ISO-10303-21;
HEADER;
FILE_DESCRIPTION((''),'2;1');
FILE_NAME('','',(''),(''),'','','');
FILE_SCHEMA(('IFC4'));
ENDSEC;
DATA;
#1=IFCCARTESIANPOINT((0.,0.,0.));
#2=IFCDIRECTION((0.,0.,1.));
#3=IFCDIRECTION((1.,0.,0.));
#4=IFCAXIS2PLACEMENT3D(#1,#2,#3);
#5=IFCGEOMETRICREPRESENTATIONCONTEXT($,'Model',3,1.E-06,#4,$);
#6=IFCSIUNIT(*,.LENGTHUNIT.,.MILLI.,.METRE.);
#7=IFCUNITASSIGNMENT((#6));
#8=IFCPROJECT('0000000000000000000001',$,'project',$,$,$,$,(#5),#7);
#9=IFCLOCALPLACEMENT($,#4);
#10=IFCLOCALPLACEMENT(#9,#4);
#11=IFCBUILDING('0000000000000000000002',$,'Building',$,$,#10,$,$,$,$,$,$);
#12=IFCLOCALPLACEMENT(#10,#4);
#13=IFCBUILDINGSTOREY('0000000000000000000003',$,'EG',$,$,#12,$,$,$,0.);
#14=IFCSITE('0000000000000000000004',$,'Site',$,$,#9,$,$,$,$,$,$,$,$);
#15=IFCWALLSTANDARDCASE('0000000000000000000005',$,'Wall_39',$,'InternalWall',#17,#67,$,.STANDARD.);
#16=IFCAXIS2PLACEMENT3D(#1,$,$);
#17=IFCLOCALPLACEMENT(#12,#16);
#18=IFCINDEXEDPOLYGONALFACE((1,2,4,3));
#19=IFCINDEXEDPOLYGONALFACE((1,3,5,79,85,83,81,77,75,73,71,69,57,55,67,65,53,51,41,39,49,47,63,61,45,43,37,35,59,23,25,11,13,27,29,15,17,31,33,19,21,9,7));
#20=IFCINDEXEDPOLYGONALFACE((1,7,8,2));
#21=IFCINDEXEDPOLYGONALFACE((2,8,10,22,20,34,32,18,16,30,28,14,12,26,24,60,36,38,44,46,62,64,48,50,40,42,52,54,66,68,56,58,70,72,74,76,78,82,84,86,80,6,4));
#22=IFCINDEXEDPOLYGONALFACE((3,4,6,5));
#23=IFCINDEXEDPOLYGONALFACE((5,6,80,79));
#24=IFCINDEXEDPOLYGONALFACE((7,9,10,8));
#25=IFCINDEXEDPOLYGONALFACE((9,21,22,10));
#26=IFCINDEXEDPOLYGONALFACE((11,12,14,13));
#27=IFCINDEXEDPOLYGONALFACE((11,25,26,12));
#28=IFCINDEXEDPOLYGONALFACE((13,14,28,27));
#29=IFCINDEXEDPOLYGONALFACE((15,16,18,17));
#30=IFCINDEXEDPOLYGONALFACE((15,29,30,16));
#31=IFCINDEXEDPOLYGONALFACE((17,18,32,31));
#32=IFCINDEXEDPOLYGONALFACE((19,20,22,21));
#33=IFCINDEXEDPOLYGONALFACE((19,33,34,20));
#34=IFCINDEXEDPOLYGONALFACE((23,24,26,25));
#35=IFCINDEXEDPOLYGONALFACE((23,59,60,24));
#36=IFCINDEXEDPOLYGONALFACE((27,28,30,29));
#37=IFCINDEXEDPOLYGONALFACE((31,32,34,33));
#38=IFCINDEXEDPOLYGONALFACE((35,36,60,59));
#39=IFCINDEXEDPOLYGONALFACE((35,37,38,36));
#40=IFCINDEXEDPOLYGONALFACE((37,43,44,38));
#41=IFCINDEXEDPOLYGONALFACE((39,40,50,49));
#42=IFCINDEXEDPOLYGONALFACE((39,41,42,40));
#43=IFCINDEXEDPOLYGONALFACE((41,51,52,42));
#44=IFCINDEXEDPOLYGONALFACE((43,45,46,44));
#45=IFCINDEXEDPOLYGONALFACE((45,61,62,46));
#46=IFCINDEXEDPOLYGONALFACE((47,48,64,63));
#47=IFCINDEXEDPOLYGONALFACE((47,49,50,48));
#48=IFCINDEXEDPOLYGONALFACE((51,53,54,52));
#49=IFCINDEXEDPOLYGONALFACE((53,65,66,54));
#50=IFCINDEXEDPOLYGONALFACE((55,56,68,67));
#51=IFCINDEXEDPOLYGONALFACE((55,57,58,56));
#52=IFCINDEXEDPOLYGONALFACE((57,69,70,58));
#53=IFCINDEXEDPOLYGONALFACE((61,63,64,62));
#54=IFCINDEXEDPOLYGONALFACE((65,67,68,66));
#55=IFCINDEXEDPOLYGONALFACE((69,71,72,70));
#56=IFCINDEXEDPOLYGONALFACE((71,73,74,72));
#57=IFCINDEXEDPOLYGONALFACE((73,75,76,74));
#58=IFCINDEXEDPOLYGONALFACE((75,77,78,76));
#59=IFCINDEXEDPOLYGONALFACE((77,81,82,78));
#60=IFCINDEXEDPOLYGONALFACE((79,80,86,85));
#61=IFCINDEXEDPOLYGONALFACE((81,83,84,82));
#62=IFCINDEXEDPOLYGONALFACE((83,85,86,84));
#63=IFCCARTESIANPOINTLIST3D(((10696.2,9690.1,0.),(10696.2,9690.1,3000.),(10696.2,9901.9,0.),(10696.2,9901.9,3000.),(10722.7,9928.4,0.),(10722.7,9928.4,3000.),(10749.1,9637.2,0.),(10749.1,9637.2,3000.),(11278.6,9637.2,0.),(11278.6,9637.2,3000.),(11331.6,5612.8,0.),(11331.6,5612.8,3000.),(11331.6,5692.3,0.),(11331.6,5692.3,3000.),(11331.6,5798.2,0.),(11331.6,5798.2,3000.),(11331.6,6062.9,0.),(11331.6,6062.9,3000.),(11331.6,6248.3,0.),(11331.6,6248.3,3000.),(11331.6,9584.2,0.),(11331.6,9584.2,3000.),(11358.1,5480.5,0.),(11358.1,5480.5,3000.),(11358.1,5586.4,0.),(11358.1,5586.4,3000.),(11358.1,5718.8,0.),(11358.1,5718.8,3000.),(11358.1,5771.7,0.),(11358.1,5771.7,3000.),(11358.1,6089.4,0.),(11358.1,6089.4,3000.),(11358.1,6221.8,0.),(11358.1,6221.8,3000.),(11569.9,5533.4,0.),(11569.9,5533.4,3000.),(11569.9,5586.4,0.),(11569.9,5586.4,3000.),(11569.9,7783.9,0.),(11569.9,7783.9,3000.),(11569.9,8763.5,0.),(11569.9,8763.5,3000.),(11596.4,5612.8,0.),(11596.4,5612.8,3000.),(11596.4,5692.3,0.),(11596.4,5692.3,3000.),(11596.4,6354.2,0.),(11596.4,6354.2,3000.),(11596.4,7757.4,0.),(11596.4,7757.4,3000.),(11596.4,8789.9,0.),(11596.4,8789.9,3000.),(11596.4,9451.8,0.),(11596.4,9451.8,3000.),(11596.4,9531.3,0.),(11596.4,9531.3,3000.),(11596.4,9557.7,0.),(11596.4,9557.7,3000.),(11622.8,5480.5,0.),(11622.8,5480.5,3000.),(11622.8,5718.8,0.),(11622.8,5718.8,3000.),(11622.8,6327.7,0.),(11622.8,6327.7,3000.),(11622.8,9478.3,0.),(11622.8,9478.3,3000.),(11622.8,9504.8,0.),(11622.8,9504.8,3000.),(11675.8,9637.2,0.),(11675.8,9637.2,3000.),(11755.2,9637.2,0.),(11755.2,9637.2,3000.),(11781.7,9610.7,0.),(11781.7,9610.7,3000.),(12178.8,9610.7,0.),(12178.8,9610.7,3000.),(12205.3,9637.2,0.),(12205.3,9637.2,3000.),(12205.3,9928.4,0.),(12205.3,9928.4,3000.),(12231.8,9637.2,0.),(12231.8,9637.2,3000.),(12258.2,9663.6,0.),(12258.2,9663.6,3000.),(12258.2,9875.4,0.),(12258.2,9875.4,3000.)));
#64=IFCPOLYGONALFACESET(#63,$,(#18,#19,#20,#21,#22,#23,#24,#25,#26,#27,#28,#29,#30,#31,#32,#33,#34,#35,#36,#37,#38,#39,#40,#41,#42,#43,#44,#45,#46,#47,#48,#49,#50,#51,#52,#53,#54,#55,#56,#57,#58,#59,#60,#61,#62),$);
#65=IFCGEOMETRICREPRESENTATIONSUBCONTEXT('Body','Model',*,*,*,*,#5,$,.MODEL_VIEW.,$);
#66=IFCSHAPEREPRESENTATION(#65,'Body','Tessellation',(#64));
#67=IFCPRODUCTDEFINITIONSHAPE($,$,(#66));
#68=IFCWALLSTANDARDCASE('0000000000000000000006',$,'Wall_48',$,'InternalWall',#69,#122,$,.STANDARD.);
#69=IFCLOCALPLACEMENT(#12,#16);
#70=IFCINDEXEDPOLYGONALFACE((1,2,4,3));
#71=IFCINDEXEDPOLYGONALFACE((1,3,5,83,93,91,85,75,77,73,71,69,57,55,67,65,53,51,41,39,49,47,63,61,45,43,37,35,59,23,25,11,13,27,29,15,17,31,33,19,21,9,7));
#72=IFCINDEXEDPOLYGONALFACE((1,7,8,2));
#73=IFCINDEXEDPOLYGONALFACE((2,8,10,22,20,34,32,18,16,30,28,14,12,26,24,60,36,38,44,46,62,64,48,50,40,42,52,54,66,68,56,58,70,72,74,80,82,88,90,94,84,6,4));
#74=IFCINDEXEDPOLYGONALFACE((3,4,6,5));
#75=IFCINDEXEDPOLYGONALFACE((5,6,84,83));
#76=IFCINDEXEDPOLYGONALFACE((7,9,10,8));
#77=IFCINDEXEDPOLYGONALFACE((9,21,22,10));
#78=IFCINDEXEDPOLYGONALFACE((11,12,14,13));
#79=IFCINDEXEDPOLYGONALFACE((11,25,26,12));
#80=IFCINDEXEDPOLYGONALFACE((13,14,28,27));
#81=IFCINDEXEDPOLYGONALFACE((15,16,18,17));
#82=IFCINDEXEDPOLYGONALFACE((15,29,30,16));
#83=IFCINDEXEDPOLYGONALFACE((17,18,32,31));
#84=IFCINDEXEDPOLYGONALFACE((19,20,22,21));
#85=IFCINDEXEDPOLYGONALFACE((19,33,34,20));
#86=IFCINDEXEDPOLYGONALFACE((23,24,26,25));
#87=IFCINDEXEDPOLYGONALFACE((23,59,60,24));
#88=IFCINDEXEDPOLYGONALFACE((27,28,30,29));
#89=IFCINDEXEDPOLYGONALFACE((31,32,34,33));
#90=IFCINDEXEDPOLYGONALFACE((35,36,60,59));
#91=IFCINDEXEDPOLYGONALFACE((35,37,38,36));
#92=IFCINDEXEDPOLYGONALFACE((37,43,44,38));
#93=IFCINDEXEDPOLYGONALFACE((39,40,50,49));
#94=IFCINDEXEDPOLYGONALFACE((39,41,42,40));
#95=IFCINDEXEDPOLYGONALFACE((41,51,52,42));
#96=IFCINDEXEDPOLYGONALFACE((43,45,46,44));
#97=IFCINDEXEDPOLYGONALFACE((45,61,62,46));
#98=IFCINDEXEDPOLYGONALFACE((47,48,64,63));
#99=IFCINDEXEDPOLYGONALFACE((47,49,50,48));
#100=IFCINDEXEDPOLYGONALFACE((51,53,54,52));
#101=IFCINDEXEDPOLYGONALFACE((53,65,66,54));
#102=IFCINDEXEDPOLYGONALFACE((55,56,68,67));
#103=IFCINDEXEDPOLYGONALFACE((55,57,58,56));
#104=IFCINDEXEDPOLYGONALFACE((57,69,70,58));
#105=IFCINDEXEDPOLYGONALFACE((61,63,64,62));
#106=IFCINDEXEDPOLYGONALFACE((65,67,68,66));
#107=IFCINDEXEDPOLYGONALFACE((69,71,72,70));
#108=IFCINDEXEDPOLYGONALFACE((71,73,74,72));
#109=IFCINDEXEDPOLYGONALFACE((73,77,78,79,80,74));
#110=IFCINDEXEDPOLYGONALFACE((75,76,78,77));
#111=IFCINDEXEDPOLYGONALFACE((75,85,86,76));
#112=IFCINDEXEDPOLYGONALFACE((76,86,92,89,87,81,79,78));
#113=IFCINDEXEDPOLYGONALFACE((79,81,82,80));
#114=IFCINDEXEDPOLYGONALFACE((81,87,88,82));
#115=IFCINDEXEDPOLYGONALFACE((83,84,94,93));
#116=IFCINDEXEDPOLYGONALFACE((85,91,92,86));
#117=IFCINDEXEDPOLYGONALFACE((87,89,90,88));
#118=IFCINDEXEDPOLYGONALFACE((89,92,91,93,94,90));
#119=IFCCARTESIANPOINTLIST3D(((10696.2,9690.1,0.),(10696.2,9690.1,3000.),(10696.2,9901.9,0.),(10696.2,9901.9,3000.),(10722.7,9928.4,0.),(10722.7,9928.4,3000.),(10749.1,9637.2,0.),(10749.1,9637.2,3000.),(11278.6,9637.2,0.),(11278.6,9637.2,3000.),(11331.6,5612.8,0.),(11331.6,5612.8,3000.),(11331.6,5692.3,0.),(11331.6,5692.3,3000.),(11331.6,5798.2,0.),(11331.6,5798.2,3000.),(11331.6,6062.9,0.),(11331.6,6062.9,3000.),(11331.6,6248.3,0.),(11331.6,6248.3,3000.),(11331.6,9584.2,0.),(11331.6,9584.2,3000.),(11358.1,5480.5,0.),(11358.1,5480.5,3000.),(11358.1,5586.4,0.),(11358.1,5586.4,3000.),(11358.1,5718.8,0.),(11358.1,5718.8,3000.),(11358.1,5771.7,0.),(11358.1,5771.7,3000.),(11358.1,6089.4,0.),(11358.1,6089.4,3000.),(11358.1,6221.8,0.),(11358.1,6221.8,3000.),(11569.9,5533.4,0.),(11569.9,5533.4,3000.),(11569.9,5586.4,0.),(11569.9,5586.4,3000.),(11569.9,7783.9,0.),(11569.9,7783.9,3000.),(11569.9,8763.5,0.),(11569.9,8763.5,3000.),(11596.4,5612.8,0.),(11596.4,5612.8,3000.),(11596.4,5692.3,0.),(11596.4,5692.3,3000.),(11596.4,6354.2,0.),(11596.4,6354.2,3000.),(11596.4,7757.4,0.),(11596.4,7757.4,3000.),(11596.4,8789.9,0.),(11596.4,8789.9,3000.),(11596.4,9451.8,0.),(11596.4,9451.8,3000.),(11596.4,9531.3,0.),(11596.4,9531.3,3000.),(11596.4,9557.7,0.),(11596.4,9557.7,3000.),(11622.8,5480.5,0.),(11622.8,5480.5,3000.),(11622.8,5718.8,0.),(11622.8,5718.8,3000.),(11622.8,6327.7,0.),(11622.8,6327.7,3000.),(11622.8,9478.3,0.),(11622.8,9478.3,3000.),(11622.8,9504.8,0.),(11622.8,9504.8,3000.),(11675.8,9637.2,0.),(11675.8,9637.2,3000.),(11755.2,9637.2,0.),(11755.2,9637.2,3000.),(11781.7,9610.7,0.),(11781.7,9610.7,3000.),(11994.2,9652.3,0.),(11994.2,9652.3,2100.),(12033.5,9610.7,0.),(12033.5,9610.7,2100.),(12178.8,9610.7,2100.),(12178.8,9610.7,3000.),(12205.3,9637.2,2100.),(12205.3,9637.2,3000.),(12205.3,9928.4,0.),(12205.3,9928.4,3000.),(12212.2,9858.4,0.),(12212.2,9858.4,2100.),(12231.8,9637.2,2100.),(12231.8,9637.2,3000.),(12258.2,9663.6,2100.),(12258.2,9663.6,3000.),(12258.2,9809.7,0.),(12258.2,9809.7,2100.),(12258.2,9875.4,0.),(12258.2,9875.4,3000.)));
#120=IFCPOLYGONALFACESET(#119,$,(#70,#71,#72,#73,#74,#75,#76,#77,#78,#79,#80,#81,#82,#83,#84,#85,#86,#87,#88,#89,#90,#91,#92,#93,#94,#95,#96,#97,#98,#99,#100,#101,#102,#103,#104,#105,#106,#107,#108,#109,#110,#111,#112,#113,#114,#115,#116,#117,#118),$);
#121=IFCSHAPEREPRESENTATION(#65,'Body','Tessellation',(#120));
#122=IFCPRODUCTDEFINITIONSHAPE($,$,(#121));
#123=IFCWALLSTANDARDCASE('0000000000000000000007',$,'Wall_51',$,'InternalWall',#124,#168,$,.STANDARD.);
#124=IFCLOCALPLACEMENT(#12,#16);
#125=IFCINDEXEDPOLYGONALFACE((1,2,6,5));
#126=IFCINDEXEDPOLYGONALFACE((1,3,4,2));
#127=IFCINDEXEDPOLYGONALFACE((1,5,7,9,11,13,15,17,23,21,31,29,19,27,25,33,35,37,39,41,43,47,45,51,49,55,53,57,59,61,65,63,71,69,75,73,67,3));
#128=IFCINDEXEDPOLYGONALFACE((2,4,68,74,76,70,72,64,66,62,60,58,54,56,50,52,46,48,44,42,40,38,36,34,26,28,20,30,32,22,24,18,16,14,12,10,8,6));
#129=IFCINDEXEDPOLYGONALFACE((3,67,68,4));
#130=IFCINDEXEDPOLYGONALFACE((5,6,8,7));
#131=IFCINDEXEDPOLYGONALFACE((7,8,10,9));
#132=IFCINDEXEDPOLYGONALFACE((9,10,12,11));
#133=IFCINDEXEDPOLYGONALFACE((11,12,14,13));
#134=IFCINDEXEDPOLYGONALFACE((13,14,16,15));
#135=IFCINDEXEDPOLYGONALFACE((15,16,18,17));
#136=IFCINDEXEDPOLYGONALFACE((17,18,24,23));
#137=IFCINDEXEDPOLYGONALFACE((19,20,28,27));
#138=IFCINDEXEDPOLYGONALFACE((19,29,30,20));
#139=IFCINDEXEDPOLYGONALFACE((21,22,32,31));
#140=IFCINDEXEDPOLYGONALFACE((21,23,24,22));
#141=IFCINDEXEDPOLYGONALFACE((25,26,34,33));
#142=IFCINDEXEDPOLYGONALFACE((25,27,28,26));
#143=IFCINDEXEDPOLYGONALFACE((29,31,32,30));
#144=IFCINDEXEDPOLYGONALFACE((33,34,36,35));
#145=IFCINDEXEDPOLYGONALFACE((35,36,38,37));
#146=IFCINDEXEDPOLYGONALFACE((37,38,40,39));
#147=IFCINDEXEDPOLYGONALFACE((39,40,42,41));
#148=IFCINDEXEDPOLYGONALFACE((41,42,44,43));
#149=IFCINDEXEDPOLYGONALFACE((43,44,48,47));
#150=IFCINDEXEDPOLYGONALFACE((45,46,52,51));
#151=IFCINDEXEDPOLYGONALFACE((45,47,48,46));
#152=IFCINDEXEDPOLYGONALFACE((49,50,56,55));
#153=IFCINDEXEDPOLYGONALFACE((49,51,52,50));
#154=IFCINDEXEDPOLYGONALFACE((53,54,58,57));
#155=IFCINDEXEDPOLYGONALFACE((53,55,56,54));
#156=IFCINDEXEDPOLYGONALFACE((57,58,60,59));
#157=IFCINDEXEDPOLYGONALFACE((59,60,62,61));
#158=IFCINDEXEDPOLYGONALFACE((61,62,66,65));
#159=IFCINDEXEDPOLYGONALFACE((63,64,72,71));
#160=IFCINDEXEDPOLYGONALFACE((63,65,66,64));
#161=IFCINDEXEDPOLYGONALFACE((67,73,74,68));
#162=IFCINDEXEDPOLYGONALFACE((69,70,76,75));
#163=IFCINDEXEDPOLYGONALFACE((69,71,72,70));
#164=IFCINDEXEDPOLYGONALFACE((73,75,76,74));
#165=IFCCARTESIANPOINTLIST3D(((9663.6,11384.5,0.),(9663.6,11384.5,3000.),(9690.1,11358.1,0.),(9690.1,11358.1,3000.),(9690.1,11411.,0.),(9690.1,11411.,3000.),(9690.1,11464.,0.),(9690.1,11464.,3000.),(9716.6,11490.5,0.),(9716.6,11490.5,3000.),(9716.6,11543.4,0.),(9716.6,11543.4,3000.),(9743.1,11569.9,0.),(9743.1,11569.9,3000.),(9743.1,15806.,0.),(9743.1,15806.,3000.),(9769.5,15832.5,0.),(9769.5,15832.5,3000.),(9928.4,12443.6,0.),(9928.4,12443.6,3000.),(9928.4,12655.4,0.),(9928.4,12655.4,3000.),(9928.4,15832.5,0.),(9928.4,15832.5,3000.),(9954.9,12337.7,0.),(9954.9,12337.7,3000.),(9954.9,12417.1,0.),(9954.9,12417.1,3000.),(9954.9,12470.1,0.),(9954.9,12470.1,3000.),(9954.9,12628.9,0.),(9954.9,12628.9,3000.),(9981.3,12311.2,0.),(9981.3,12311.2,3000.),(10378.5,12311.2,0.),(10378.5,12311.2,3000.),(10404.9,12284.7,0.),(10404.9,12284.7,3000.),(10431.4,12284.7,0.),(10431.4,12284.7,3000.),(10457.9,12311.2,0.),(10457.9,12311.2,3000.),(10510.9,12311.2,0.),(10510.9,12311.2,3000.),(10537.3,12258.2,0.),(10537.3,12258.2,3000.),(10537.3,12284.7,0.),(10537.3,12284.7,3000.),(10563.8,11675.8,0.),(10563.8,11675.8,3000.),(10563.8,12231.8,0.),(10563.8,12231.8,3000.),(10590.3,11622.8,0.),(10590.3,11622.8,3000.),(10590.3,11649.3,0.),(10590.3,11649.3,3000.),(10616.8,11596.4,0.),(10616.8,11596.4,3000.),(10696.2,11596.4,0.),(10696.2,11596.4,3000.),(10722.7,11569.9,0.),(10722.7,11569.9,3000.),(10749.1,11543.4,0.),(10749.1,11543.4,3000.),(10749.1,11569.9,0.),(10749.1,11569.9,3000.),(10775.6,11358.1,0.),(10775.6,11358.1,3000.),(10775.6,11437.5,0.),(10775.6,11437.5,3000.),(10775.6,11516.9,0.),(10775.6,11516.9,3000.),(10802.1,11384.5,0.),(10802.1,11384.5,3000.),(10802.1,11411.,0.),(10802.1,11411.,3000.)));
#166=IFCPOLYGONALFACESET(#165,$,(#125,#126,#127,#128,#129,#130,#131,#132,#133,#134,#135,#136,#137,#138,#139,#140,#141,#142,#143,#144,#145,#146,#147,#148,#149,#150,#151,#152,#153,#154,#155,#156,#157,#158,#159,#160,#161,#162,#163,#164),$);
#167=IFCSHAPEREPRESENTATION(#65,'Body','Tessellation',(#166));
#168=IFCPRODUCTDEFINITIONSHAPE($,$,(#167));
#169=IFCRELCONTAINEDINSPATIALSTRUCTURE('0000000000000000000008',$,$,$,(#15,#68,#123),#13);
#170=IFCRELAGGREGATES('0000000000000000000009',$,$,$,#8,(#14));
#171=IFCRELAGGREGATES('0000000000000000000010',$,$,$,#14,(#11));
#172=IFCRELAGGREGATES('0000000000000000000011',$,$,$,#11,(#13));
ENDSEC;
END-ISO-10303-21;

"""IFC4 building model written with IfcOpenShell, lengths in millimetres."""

from ifc_helpers import new_model, si_unit, frame, origin_with_axes, place, context, subcontext, project, spatial, polyline, rectangle, outline, extrude, element, save


model = new_model("IFC4")

# Units and contexts
model_context = context("Model", 3, precision=1e-06, world=origin_with_axes())
body_context = subcontext(model_context, "Body", "Model", "MODEL_VIEW")
ifc_project = project(units=[si_unit("LENGTHUNIT", "METRE", prefix="MILLI")], contexts=[model_context])

# Site, building, storey
site_placement = place(None, origin_with_axes())
site = spatial("IfcSite", under=ifc_project, at=site_placement, Name="Site")
building_placement = place(site_placement, origin_with_axes())
building = spatial("IfcBuilding", under=site, at=building_placement, Name="Building")
storey_placement = place(building_placement, origin_with_axes())
storey = spatial("IfcBuildingStorey", under=building, at=storey_placement, Name="EG", Elevation=0.0)

# Wall
wall_1_placement = place(storey_placement, origin_with_axes())
element("IfcWallStandardCase", 1, at=wall_1_placement, inside=storey, Name="Wall_39", ObjectType="InternalWall", PredefinedType="STANDARD", context=body_context, shape_type="SweptSolid", body=[
    extrude(outline(polyline([(11358.1, 5480.5, 0.0), (11358.1, 5586.4, 0.0), (11331.6, 5612.8, 0.0), (11331.6, 5692.3, 0.0), (11358.1, 5718.8, 0.0), (11358.1, 5771.7, 0.0), (11331.6, 5798.2, 0.0), (11331.6, 6062.9, 0.0), (11358.1, 6089.4, 0.0), (11358.1, 6221.8, 0.0), (11331.6, 6248.3, 0.0), (11331.6, 9584.2, 0.0), (11278.6, 9637.2, 0.0), (10749.1, 9637.2, 0.0), (10696.2, 9690.1, 0.0), (10696.2, 9901.9, 0.0), (10722.7, 9928.4, 0.0), (12205.3, 9928.4, 0.0), (12258.2, 9875.4, 0.0), (12258.2, 9663.6, 0.0), (12231.8, 9637.2, 0.0), (12205.3, 9637.2, 0.0), (12178.8, 9610.7, 0.0), (11781.7, 9610.7, 0.0), (11755.2, 9637.2, 0.0), (11675.8, 9637.2, 0.0), (11596.4, 9557.7, 0.0), (11596.4, 9531.3, 0.0), (11622.8, 9504.8, 0.0), (11622.8, 9478.3, 0.0), (11596.4, 9451.8, 0.0), (11596.4, 8789.9, 0.0), (11569.9, 8763.5, 0.0), (11569.9, 7783.9, 0.0), (11596.4, 7757.4, 0.0), (11596.4, 6354.2, 0.0), (11622.8, 6327.7, 0.0), (11622.8, 5718.8, 0.0), (11596.4, 5692.3, 0.0), (11596.4, 5612.8, 0.0), (11569.9, 5586.4, 0.0), (11569.9, 5533.4, 0.0), (11622.8, 5480.5, 0.0), (11358.1, 5480.5, 0.0)])), origin_with_axes(), (0.0, 0.0, 1.0), 3000.0),
])

# Wall, opening
wall_2_placement = place(storey_placement, origin_with_axes())
wall_2 = element("IfcWallStandardCase", 2, at=wall_2_placement, inside=storey, Name="Wall_48", ObjectType="InternalWall", PredefinedType="STANDARD", context=body_context, shape_type="SweptSolid", body=[
    extrude(outline(polyline([(11358.1, 5480.5, 0.0), (11358.1, 5586.4, 0.0), (11331.6, 5612.8, 0.0), (11331.6, 5692.3, 0.0), (11358.1, 5718.8, 0.0), (11358.1, 5771.7, 0.0), (11331.6, 5798.2, 0.0), (11331.6, 6062.9, 0.0), (11358.1, 6089.4, 0.0), (11358.1, 6221.8, 0.0), (11331.6, 6248.3, 0.0), (11331.6, 9584.2, 0.0), (11278.6, 9637.2, 0.0), (10749.1, 9637.2, 0.0), (10696.2, 9690.1, 0.0), (10696.2, 9901.9, 0.0), (10722.7, 9928.4, 0.0), (12205.3, 9928.4, 0.0), (12258.2, 9875.4, 0.0), (12258.2, 9663.6, 0.0), (12231.8, 9637.2, 0.0), (12205.3, 9637.2, 0.0), (12178.8, 9610.7, 0.0), (11781.7, 9610.7, 0.0), (11755.2, 9637.2, 0.0), (11675.8, 9637.2, 0.0), (11596.4, 9557.7, 0.0), (11596.4, 9531.3, 0.0), (11622.8, 9504.8, 0.0), (11622.8, 9478.3, 0.0), (11596.4, 9451.8, 0.0), (11596.4, 8789.9, 0.0), (11569.9, 8763.5, 0.0), (11569.9, 7783.9, 0.0), (11596.4, 7757.4, 0.0), (11596.4, 6354.2, 0.0), (11622.8, 6327.7, 0.0), (11622.8, 5718.8, 0.0), (11596.4, 5692.3, 0.0), (11596.4, 5612.8, 0.0), (11569.9, 5586.4, 0.0), (11569.9, 5533.4, 0.0), (11622.8, 5480.5, 0.0), (11358.1, 5480.5, 0.0)])), origin_with_axes(), (0.0, 0.0, 1.0), 3000.0),
])
opening_1_placement = place(wall_2_placement, origin_with_axes())
element("IfcOpeningElement", 3, at=opening_1_placement, inside=storey, cuts=wall_2, context=body_context, shape_type="SweptSolid", body=[
    extrude(rectangle(XDim=1319.5, YDim=300.0), frame((12556.4, 9275.9, 0.0), z_axis=(0.0, 0.0, 1.0), x_axis=(0.686906, -0.726747, 0.0)), (0.0, 0.0, 1.0), 2100.0),
])

# Wall
for number, where, z_axis, x_axis, name in (
    (4, (0.0, 0.0, 0.0), (0.0, 0.0, 1.0), (1.0, 0.0, 0.0), "Wall_51"),
):
    element("IfcWallStandardCase", number, at=place(storey_placement, frame(where, z_axis=z_axis, x_axis=x_axis)), inside=storey, Name=name, ObjectType="InternalWall", PredefinedType="STANDARD", context=body_context, shape_type="SweptSolid", body=[
        extrude(outline(polyline([(9690.1, 11358.1, 0.0), (9663.6, 11384.5, 0.0), (9690.1, 11411.0, 0.0), (9690.1, 11464.0, 0.0), (9716.6, 11490.5, 0.0), (9716.6, 11543.4, 0.0), (9743.1, 11569.9, 0.0), (9743.1, 15806.0, 0.0), (9769.5, 15832.5, 0.0), (9928.4, 15832.5, 0.0), (9928.4, 12655.4, 0.0), (9954.9, 12628.9, 0.0), (9954.9, 12470.1, 0.0), (9928.4, 12443.6, 0.0), (9954.9, 12417.1, 0.0), (9954.9, 12337.7, 0.0), (9981.3, 12311.2, 0.0), (10378.5, 12311.2, 0.0), (10404.9, 12284.7, 0.0), (10431.4, 12284.7, 0.0), (10457.9, 12311.2, 0.0), (10510.9, 12311.2, 0.0), (10537.3, 12284.7, 0.0), (10537.3, 12258.2, 0.0), (10563.8, 12231.8, 0.0), (10563.8, 11675.8, 0.0), (10590.3, 11649.3, 0.0), (10590.3, 11622.8, 0.0), (10616.8, 11596.4, 0.0), (10696.2, 11596.4, 0.0), (10722.7, 11569.9, 0.0), (10749.1, 11569.9, 0.0), (10749.1, 11543.4, 0.0), (10775.6, 11516.9, 0.0), (10775.6, 11437.5, 0.0), (10802.1, 11411.0, 0.0), (10802.1, 11384.5, 0.0), (10775.6, 11358.1, 0.0), (9690.1, 11358.1, 0.0)])), origin_with_axes(), (0.0, 0.0, 1.0), 3000.0),
    ])

save(model, "model.ifc")
